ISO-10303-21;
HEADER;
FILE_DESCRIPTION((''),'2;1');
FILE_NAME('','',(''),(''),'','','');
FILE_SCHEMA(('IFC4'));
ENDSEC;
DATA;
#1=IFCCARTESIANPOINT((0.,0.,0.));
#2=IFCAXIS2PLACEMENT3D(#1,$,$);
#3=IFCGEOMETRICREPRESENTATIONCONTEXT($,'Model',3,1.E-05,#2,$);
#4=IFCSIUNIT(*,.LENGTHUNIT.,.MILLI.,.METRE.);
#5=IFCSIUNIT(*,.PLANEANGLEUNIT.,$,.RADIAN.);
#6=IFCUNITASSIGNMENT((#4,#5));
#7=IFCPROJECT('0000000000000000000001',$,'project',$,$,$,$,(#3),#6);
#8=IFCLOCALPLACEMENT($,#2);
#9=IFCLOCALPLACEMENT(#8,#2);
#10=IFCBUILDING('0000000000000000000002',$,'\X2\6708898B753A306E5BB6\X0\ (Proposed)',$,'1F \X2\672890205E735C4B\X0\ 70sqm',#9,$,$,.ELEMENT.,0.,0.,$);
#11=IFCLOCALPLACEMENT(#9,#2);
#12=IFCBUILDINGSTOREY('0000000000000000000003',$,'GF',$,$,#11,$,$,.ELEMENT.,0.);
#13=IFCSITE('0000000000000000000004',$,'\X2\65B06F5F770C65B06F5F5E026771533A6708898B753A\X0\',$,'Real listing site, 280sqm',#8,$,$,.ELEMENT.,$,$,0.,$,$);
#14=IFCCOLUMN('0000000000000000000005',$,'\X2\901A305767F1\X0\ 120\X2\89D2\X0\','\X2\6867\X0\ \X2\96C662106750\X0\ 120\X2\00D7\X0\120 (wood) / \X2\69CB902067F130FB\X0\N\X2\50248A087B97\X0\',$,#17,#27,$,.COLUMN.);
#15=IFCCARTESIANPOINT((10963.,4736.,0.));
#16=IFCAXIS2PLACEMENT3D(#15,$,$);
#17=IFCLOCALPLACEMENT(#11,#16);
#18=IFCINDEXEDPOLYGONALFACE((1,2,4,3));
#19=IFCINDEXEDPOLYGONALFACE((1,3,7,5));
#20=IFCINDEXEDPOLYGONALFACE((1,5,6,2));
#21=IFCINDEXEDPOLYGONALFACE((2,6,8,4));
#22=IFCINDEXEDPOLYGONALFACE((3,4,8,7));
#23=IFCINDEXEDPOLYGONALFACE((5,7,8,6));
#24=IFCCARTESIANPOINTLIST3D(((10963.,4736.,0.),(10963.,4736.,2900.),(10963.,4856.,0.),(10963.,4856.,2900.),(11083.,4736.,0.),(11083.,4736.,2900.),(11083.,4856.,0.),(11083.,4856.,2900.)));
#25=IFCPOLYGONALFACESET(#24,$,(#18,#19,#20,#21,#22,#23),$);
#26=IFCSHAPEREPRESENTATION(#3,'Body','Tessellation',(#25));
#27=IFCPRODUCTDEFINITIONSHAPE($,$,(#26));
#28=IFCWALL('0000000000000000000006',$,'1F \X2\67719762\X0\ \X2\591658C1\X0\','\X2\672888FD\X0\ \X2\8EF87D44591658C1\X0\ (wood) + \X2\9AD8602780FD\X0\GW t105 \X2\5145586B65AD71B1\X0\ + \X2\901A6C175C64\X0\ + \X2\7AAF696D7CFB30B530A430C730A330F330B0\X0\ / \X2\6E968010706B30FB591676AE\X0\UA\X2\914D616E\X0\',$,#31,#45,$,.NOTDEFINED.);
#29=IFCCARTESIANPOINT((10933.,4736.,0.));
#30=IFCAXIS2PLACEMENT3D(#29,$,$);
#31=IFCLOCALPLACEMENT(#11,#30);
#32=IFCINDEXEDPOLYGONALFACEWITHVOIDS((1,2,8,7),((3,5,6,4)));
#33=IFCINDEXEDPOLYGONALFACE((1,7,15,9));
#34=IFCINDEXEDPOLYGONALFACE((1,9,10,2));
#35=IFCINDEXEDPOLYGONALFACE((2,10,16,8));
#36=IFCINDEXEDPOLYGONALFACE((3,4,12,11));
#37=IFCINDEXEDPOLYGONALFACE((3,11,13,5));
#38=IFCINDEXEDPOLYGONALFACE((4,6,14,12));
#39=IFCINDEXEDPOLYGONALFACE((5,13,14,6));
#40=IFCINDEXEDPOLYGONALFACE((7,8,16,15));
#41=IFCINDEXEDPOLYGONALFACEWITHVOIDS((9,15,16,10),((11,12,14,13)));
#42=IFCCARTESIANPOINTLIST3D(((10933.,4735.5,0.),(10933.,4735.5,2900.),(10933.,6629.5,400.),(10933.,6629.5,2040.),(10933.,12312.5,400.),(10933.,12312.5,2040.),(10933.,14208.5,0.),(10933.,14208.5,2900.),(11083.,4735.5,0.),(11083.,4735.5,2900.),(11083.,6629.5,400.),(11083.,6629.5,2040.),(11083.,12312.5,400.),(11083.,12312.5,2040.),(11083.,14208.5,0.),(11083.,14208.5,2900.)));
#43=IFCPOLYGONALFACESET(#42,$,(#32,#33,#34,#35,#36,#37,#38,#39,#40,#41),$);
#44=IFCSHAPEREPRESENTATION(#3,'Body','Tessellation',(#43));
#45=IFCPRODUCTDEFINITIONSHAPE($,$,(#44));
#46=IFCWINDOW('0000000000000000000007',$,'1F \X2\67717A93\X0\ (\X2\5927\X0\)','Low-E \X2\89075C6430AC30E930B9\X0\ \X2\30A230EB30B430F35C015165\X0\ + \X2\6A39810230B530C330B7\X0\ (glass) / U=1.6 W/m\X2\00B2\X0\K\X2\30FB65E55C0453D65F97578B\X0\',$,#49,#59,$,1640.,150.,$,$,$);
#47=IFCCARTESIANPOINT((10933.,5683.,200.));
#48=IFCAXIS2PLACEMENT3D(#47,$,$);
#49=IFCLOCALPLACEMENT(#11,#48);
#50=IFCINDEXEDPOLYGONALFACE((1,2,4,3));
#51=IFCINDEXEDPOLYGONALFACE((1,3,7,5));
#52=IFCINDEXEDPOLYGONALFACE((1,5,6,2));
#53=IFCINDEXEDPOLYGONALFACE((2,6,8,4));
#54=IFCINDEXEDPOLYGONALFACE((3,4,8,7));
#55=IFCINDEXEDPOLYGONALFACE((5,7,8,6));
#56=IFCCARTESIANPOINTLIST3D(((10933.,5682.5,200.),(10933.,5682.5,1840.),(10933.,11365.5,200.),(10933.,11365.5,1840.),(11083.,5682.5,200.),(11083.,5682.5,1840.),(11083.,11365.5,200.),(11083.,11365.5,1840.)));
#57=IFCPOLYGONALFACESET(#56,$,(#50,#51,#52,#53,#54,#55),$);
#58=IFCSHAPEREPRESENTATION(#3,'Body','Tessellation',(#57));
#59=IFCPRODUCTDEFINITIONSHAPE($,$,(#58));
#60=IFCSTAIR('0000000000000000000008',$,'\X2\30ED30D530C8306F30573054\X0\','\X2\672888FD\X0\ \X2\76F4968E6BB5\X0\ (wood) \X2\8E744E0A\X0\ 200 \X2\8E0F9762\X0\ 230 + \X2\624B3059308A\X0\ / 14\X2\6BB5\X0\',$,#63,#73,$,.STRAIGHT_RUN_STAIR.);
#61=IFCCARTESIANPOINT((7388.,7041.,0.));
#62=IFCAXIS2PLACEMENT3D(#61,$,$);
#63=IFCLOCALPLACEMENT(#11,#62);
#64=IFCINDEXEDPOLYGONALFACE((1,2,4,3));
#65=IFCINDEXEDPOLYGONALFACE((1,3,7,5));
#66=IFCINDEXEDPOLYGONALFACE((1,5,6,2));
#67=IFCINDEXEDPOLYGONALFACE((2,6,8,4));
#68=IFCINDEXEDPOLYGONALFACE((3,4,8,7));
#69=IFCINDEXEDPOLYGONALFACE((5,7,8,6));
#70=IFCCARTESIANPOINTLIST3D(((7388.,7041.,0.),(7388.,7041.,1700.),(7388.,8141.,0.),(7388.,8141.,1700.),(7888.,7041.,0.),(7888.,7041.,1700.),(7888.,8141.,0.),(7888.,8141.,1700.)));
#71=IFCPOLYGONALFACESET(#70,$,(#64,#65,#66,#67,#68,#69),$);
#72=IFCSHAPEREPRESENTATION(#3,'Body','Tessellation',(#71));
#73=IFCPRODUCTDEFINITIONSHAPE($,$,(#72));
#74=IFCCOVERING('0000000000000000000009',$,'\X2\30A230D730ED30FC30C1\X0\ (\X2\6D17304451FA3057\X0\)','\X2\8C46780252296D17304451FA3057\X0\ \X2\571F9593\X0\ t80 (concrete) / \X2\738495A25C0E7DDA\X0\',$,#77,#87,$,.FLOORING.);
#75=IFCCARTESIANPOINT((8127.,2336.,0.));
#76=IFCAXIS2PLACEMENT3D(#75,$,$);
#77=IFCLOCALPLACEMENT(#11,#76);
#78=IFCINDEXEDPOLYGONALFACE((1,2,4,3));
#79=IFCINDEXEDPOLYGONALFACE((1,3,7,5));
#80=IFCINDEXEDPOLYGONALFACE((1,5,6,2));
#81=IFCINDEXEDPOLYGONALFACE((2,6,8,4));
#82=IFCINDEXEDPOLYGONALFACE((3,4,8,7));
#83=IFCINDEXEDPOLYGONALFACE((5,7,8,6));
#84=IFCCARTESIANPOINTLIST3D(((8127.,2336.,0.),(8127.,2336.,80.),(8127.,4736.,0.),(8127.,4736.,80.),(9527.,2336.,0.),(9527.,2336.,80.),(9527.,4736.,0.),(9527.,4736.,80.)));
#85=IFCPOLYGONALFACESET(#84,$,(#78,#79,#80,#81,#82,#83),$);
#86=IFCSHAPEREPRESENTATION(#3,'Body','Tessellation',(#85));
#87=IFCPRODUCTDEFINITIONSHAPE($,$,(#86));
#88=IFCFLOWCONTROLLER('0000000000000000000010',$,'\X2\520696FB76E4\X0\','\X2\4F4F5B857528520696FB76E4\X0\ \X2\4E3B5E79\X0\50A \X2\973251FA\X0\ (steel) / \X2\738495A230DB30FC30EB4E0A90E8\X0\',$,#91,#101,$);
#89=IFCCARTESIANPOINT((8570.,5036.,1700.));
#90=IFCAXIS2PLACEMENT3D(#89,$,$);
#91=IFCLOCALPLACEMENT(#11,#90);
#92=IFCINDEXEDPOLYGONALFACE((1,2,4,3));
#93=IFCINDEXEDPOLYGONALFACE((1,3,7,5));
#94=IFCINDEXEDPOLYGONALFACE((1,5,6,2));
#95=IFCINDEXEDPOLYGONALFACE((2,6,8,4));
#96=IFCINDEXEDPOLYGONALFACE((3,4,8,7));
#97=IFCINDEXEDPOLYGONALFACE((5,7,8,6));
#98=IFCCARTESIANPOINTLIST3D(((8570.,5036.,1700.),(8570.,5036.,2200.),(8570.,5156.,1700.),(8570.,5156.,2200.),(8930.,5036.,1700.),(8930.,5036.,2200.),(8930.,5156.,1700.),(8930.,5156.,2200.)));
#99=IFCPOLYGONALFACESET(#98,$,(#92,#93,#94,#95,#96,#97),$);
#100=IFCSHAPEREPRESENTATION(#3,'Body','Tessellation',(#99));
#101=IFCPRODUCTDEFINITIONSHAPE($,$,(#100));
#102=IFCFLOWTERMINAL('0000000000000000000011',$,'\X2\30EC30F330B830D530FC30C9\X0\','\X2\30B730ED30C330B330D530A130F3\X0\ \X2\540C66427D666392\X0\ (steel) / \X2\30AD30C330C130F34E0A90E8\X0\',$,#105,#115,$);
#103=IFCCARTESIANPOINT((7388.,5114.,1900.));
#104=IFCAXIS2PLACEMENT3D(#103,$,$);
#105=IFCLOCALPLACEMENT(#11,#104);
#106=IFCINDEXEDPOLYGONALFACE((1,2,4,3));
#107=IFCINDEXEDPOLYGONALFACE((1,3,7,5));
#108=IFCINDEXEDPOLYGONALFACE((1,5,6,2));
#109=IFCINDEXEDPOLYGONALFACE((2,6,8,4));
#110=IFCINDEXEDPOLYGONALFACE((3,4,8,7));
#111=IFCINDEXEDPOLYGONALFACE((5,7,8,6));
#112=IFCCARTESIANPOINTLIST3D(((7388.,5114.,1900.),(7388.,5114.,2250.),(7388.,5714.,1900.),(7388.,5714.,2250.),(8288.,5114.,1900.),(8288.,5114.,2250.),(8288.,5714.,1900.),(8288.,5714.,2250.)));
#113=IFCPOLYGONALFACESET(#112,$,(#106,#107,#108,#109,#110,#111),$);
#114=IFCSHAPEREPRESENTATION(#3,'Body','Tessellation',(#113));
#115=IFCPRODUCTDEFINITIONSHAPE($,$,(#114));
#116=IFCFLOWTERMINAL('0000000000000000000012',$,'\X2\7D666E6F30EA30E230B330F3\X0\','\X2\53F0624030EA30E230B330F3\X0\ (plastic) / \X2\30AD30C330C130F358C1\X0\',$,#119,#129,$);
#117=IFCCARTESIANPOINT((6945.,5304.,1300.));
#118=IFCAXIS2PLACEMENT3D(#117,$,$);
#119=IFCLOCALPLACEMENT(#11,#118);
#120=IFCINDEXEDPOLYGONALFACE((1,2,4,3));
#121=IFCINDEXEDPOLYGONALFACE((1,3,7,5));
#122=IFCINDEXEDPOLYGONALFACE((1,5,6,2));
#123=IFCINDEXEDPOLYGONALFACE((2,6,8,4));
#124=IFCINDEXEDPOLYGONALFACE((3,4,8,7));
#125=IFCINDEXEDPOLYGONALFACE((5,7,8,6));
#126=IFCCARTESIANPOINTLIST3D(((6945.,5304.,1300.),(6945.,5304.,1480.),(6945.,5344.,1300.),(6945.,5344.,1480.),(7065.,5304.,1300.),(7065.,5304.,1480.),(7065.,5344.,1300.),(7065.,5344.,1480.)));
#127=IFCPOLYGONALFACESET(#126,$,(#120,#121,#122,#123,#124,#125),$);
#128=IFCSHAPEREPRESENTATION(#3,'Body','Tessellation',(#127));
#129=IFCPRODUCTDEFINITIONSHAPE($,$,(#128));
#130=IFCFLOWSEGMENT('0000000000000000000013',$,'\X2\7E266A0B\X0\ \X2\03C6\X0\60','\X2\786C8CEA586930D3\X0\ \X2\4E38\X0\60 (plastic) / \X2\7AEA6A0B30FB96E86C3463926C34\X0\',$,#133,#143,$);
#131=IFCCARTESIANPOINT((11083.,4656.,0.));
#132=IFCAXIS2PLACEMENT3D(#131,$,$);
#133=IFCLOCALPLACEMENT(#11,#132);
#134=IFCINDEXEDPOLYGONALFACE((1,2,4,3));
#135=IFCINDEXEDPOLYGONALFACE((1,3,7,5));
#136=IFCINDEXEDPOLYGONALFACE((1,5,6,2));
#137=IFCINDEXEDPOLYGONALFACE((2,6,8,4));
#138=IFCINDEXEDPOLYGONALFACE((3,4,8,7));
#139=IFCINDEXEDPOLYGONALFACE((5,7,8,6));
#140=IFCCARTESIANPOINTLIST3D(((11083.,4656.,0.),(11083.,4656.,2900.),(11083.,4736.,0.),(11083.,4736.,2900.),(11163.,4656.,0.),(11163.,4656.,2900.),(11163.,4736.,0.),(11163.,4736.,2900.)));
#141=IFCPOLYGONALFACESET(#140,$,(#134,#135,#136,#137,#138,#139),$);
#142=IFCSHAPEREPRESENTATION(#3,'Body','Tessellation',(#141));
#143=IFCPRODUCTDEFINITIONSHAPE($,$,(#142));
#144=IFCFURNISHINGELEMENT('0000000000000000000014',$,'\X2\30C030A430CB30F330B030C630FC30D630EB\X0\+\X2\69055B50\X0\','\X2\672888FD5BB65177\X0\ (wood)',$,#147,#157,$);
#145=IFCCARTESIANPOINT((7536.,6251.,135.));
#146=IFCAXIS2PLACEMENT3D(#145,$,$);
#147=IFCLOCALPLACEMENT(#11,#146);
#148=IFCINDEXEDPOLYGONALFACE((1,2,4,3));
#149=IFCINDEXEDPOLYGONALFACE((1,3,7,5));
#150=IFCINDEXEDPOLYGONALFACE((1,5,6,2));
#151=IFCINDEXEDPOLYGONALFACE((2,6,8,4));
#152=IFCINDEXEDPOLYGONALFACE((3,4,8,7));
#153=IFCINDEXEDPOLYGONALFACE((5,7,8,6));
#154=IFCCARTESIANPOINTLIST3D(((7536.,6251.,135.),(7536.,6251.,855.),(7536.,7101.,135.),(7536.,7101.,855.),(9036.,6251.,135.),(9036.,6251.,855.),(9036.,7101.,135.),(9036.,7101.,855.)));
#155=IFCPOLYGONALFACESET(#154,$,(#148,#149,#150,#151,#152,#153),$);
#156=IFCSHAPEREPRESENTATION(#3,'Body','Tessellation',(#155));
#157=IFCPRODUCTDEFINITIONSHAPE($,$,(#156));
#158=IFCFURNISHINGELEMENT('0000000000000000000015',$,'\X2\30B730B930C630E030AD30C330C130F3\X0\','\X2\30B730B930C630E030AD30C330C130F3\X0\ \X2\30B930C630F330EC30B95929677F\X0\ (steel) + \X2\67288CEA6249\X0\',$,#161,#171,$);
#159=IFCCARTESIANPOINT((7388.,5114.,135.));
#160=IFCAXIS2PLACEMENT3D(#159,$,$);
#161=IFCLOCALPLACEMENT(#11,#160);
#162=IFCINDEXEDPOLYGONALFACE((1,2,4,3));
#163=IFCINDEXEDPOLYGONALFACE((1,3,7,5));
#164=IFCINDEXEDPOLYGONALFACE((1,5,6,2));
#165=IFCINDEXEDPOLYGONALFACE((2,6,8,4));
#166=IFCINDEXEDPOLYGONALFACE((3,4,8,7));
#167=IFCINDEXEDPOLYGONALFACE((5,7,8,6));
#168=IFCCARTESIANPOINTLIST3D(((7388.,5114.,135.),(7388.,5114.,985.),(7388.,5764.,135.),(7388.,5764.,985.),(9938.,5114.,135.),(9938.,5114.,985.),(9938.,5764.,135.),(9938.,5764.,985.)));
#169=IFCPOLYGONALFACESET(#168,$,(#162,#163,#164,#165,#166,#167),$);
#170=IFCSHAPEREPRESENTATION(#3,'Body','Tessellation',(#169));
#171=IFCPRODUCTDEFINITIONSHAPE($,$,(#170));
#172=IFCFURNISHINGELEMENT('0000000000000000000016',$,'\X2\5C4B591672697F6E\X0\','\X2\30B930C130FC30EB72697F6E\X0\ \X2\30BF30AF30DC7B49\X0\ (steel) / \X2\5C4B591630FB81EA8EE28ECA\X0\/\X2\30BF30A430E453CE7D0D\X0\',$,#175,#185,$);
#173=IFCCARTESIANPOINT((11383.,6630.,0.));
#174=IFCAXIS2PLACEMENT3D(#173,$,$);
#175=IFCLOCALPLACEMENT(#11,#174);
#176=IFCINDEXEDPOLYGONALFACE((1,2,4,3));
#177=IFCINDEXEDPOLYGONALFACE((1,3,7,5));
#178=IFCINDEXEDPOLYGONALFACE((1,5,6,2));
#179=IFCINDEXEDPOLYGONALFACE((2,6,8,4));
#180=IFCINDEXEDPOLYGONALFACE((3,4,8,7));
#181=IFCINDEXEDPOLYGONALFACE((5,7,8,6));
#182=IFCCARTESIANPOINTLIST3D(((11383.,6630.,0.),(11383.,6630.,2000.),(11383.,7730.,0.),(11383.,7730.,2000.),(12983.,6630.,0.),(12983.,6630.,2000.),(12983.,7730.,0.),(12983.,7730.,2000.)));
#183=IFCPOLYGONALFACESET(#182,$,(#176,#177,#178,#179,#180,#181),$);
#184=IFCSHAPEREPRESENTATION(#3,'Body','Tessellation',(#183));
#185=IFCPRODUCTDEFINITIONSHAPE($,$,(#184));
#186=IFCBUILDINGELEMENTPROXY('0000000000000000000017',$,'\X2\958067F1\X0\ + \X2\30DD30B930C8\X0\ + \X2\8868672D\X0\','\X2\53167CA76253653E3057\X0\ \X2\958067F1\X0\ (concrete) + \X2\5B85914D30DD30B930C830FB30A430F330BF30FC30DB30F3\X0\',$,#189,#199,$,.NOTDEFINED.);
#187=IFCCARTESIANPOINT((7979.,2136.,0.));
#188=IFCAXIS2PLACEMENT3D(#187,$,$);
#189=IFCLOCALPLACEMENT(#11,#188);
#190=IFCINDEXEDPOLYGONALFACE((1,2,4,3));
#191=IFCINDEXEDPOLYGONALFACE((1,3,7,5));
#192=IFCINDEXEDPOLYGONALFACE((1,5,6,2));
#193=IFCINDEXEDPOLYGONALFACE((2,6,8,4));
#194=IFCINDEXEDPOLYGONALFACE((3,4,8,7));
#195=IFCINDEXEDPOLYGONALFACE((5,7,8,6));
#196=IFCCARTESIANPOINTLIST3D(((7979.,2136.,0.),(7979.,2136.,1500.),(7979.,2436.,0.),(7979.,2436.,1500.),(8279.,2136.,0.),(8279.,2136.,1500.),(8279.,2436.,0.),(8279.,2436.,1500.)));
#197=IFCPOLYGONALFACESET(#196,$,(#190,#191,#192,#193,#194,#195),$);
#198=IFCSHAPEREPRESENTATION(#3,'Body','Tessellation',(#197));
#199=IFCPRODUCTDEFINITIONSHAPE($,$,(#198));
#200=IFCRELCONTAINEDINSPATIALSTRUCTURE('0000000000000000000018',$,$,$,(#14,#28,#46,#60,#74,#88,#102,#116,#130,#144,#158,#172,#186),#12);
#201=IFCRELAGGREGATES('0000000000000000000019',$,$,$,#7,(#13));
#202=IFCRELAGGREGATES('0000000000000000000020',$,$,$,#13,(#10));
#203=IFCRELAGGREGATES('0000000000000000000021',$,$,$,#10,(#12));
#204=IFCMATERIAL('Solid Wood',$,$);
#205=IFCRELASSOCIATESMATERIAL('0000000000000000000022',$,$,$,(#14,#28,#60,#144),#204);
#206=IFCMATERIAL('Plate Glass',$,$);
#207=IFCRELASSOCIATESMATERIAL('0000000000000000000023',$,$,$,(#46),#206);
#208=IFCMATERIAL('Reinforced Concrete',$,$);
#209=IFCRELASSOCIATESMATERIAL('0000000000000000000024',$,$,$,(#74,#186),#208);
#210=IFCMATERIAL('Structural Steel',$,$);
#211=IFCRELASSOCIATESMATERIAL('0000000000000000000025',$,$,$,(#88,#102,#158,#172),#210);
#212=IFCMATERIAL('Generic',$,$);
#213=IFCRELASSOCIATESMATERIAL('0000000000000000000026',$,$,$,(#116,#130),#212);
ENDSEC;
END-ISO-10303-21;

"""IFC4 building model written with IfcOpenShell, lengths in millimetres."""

from ifc_helpers import new_model, si_unit, frame, frame_2d, origin, place, context, project, spatial, rectangle, extrude, material, element, fill, save


model = new_model("IFC4")

# Units and contexts
model_context = context("Model", 3, precision=1e-05, world=origin())
ifc_project = project(units=[si_unit("LENGTHUNIT", "METRE", prefix="MILLI"), si_unit("PLANEANGLEUNIT", "RADIAN")], contexts=[model_context])

# Site, building, storey
site_placement = place(None, origin())
site = spatial("IfcSite", under=ifc_project, at=site_placement, Name="新潟県新潟市東区月見町", ObjectType="Real listing site, 280sqm", CompositionType="ELEMENT", RefElevation=0.0)
building_placement = place(site_placement, origin())
building = spatial("IfcBuilding", under=site, at=building_placement, Name="月見町の家 (Proposed)", ObjectType="1F 木造平屋 70sqm", CompositionType="ELEMENT", ElevationOfRefHeight=0.0, ElevationOfTerrain=0.0)
storey_placement = place(building_placement, origin())
storey = spatial("IfcBuildingStorey", under=building, at=storey_placement, Name="GF", CompositionType="ELEMENT", Elevation=0.0)

# Column
ifc_material_1 = material(Name="Solid Wood")
column_1_placement = place(storey_placement, frame((10963.0, 4736.0, 0.0)))
element("IfcColumn", 1, at=column_1_placement, inside=storey, material=ifc_material_1, Name="通し柱 120角", Description="桧 集成材 120×120 (wood) / 構造柱・N値計算", PredefinedType="COLUMN", context=model_context, shape_type="SweptSolid", body=[
    extrude(rectangle(XDim=120.0, YDim=120.0, at=frame_2d((60.0, 60.0))), frame((10963.0, 4736.0, 0.0)), (0.0, 0.0, 1.0), 2900.0),
])

# Wall, opening, window
wall_1_placement = place(storey_placement, frame((10933.0, 4736.0, 0.0)))
wall_1 = element("IfcWall", 2, at=wall_1_placement, inside=storey, material=ifc_material_1, Name="1F 東面 外壁", Description="木製 軸組外壁 (wood) + 高性能GW t105 充填断熱 + 通気層 + 窯業系サイディング / 準耐火・外皮UA配慮", PredefinedType="NOTDEFINED", context=model_context, shape_type="SweptSolid", body=[
    extrude(rectangle(XDim=150.0, YDim=9473.0, at=frame_2d((75.0, 4736.0))), frame((10933.0, 4736.0, 0.0)), (0.0, 0.0, 1.0), 2900.0),
])
opening_placement = place(storey_placement, frame((10933.0, 5683.0, 200.0)))
opening = element("IfcOpeningElement", 3, at=opening_placement, cuts=wall_1, PredefinedType="NOTDEFINED", context=model_context, shape_type="SweptSolid", body=[
    extrude(rectangle(XDim=150.0, YDim=5683.0, at=frame_2d((75.0, 2841.0))), frame((10933.0, 5683.0, 200.0)), (0.0, 0.0, 1.0), 1640.0),
])
ifc_material_2 = material(Name="Plate Glass")
window_placement = place(storey_placement, frame((10933.0, 5683.0, 200.0)))
window = element("IfcWindow", 4, at=window_placement, inside=storey, material=ifc_material_2, Name="1F 東窓 (大)", Description="Low-E 複層ガラス アルゴン封入 + 樹脂サッシ (glass) / U=1.6 W/m²K・日射取得型", OverallHeight=1640.0, OverallWidth=150.0, context=model_context, shape_type="SweptSolid", body=[
    extrude(rectangle(XDim=150.0, YDim=5683.0, at=frame_2d((75.0, 2841.0))), frame((10933.0, 5683.0, 200.0)), (0.0, 0.0, 1.0), 1640.0),
])
fill(opening, window)

# Stair
stair_placement = place(storey_placement, frame((7388.0, 7041.0, 0.0)))
element("IfcStair", 5, at=stair_placement, inside=storey, material=ifc_material_1, Name="ロフトはしご", Description="木製 直階段 (wood) 蹴上 200 踏面 230 + 手すり / 14段", PredefinedType="STRAIGHT_RUN_STAIR", context=model_context, shape_type="SweptSolid", body=[
    extrude(rectangle(XDim=500.0, YDim=1100.0, at=frame_2d((250.0, 550.0))), frame((7388.0, 7041.0, 0.0)), (0.0, 0.0, 1.0), 1700.0),
])

# Covering
ifc_material_3 = material(Name="Reinforced Concrete")
covering_placement = place(storey_placement, frame((8127.0, 2336.0, 0.0)))
element("IfcCovering", 6, at=covering_placement, inside=storey, material=ifc_material_3, Name="アプローチ (洗い出し)", Description="豆砂利洗い出し 土間 t80 (concrete) / 玄関導線", PredefinedType="FLOORING", context=model_context, shape_type="SweptSolid", body=[
    extrude(rectangle(XDim=1400.0, YDim=2400.0, at=frame_2d((700.0, 1200.0))), frame((8127.0, 2336.0, 0.0)), (0.0, 0.0, 1.0), 80.0),
])

# Flow controller
ifc_material_4 = material(Name="Structural Steel")
flow_controller_placement = place(storey_placement, frame((8570.0, 5036.0, 1700.0)))
element("IfcFlowController", 7, at=flow_controller_placement, inside=storey, material=ifc_material_4, Name="分電盤", Description="住宅用分電盤 主幹50A 露出 (steel) / 玄関ホール上部", context=model_context, shape_type="SweptSolid", body=[
    extrude(rectangle(XDim=360.0, YDim=120.0, at=frame_2d((180.0, 60.0))), frame((8570.0, 5036.0, 1700.0)), (0.0, 0.0, 1.0), 500.0),
])

# Flow terminals
flow_terminal_1_placement = place(storey_placement, frame((7388.0, 5114.0, 1900.0)))
element("IfcFlowTerminal", 8, at=flow_terminal_1_placement, inside=storey, material=ifc_material_4, Name="レンジフード", Description="シロッコファン 同時給排 (steel) / キッチン上部", context=model_context, shape_type="SweptSolid", body=[
    extrude(rectangle(XDim=900.0, YDim=600.0, at=frame_2d((450.0, 300.0))), frame((7388.0, 5114.0, 1900.0)), (0.0, 0.0, 1.0), 350.0),
])
ifc_material_5 = material(Name="Generic")
flow_terminal_2_placement = place(storey_placement, frame((6945.0, 5304.0, 1300.0)))
element("IfcFlowTerminal", 9, at=flow_terminal_2_placement, inside=storey, material=ifc_material_5, Name="給湯リモコン", Description="台所リモコン (plastic) / キッチン壁", context=model_context, shape_type="SweptSolid", body=[
    extrude(rectangle(XDim=120.0, YDim=40.0, at=frame_2d((60.0, 20.0))), frame((6945.0, 5304.0, 1300.0)), (0.0, 0.0, 1.0), 180.0),
])

# Flow segment
flow_segment_placement = place(storey_placement, frame((11083.0, 4656.0, 0.0)))
element("IfcFlowSegment", 10, at=flow_segment_placement, inside=storey, material=ifc_material_5, Name="縦樋 φ60", Description="硬質塩ビ 丸60 (plastic) / 竪樋・雨水排水", context=model_context, shape_type="SweptSolid", body=[
    extrude(rectangle(XDim=80.0, YDim=80.0, at=frame_2d((40.0, 40.0))), frame((11083.0, 4656.0, 0.0)), (0.0, 0.0, 1.0), 2900.0),
])

# Furnishing elements
furnishing_1_placement = place(storey_placement, frame((7536.0, 6251.0, 135.0)))
element("IfcFurnishingElement", 11, at=furnishing_1_placement, inside=storey, material=ifc_material_1, Name="ダイニングテーブル+椅子", Description="木製家具 (wood)", context=model_context, shape_type="SweptSolid", body=[
    extrude(rectangle(XDim=1500.0, YDim=850.0, at=frame_2d((750.0, 425.0))), frame((7536.0, 6251.0, 135.0)), (0.0, 0.0, 1.0), 720.0),
])
furnishing_2_placement = place(storey_placement, frame((7388.0, 5114.0, 135.0)))
element("IfcFurnishingElement", 12, at=furnishing_2_placement, inside=storey, material=ifc_material_4, Name="システムキッチン", Description="システムキッチン ステンレス天板 (steel) + 木質扉", context=model_context, shape_type="SweptSolid", body=[
    extrude(rectangle(XDim=2550.0, YDim=650.0, at=frame_2d((1275.0, 325.0))), frame((7388.0, 5114.0, 135.0)), (0.0, 0.0, 1.0), 850.0),
])
furnishing_3_placement = place(storey_placement, frame((11383.0, 6630.0, 0.0)))
element("IfcFurnishingElement", 13, at=furnishing_3_placement, inside=storey, material=ifc_material_4, Name="屋外物置", Description="スチール物置 タクボ等 (steel) / 屋外・自転車/タイヤ収納", context=model_context, shape_type="SweptSolid", body=[
    extrude(rectangle(XDim=1600.0, YDim=1100.0, at=frame_2d((800.0, 550.0))), frame((11383.0, 6630.0, 0.0)), (0.0, 0.0, 1.0), 2000.0),
])

# Building element proxy
proxy_placement = place(storey_placement, frame((7979.0, 2136.0, 0.0)))
element("IfcBuildingElementProxy", 14, at=proxy_placement, inside=storey, material=ifc_material_3, Name="門柱 + ポスト + 表札", Description="化粧打放し 門柱 (concrete) + 宅配ポスト・インターホン", PredefinedType="NOTDEFINED", context=model_context, shape_type="SweptSolid", body=[
    extrude(rectangle(XDim=300.0, YDim=300.0, at=frame_2d((150.0, 150.0))), frame((7979.0, 2136.0, 0.0)), (0.0, 0.0, 1.0), 1500.0),
])

save(model, "model.ifc")
